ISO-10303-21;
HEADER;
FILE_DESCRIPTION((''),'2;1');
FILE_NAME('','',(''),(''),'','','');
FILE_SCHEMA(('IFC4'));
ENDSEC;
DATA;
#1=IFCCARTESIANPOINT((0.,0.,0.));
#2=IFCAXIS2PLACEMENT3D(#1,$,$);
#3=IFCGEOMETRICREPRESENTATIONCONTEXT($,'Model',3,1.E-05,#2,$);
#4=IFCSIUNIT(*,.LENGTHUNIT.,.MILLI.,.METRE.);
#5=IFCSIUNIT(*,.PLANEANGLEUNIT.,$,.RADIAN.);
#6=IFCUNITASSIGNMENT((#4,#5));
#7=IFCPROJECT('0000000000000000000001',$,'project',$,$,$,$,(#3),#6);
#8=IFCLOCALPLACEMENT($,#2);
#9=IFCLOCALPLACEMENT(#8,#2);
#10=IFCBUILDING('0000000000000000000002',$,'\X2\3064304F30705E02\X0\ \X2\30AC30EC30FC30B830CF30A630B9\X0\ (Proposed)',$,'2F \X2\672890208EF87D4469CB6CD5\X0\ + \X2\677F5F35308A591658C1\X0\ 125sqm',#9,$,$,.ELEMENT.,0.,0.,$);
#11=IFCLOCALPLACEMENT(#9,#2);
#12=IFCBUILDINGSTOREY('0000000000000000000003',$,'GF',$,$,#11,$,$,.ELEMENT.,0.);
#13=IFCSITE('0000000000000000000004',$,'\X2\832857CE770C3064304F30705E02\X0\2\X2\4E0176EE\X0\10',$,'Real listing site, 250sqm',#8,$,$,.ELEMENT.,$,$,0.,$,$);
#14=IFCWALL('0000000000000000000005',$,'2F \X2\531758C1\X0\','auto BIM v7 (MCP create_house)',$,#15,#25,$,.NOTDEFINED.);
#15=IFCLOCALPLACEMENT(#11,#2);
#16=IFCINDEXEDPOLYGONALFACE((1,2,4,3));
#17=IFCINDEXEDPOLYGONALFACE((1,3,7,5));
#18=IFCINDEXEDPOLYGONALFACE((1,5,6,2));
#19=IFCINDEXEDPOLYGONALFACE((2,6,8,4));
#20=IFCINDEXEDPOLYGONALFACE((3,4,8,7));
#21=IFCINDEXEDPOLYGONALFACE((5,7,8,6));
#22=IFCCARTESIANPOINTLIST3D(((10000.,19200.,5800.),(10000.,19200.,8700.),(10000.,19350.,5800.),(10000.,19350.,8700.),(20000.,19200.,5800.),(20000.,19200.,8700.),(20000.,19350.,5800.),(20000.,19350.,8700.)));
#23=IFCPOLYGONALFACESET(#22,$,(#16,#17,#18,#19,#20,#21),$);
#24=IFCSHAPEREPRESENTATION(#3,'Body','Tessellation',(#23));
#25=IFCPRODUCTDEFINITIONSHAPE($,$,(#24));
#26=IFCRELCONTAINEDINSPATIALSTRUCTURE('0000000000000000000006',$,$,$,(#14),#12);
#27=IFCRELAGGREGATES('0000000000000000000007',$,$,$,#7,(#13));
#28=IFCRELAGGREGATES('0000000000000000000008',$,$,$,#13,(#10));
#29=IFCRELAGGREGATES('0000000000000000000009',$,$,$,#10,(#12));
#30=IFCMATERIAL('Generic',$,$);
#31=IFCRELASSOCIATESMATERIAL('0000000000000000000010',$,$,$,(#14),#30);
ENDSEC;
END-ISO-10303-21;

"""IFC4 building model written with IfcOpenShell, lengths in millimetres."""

from ifc_helpers import new_model, si_unit, frame, frame_2d, origin, place, context, project, spatial, rectangle, extrude, material, element, save


model = new_model("IFC4")

# Units and contexts
model_context = context("Model", 3, precision=1e-05, world=origin())
ifc_project = project(units=[si_unit("LENGTHUNIT", "METRE", prefix="MILLI"), si_unit("PLANEANGLEUNIT", "RADIAN")], contexts=[model_context])

# Site, building, storey
site_placement = place(None, origin())
site = spatial("IfcSite", under=ifc_project, at=site_placement, Name="茨城県つくば市2丁目10", ObjectType="Real listing site, 250sqm", CompositionType="ELEMENT", RefElevation=0.0)
building_placement = place(site_placement, origin())
building = spatial("IfcBuilding", under=site, at=building_placement, Name="つくば市 ガレージハウス (Proposed)", ObjectType="2F 木造軸組構法 + 板張り外壁 125sqm", CompositionType="ELEMENT", ElevationOfRefHeight=0.0, ElevationOfTerrain=0.0)
storey_placement = place(building_placement, origin())
storey = spatial("IfcBuildingStorey", under=building, at=storey_placement, Name="GF", CompositionType="ELEMENT", Elevation=0.0)

# Shared definitions
ifc_material = material(Name="Generic")

# Wall
wall_1_placement = place(storey_placement, frame((5000.0, 9600.0, 2900.0)))
element("IfcWall", 1, at=wall_1_placement, inside=storey, material=ifc_material, Name="2F 北壁", Description="auto BIM v7 (MCP create_house)", PredefinedType="NOTDEFINED", context=model_context, shape_type="SweptSolid", body=[
    extrude(rectangle(XDim=10000.0, YDim=150.0, at=frame_2d((5000.0, 75.0))), frame((5000.0, 9600.0, 2900.0)), (0.0, 0.0, 1.0), 2900.0),
])

save(model, "model.ifc")
